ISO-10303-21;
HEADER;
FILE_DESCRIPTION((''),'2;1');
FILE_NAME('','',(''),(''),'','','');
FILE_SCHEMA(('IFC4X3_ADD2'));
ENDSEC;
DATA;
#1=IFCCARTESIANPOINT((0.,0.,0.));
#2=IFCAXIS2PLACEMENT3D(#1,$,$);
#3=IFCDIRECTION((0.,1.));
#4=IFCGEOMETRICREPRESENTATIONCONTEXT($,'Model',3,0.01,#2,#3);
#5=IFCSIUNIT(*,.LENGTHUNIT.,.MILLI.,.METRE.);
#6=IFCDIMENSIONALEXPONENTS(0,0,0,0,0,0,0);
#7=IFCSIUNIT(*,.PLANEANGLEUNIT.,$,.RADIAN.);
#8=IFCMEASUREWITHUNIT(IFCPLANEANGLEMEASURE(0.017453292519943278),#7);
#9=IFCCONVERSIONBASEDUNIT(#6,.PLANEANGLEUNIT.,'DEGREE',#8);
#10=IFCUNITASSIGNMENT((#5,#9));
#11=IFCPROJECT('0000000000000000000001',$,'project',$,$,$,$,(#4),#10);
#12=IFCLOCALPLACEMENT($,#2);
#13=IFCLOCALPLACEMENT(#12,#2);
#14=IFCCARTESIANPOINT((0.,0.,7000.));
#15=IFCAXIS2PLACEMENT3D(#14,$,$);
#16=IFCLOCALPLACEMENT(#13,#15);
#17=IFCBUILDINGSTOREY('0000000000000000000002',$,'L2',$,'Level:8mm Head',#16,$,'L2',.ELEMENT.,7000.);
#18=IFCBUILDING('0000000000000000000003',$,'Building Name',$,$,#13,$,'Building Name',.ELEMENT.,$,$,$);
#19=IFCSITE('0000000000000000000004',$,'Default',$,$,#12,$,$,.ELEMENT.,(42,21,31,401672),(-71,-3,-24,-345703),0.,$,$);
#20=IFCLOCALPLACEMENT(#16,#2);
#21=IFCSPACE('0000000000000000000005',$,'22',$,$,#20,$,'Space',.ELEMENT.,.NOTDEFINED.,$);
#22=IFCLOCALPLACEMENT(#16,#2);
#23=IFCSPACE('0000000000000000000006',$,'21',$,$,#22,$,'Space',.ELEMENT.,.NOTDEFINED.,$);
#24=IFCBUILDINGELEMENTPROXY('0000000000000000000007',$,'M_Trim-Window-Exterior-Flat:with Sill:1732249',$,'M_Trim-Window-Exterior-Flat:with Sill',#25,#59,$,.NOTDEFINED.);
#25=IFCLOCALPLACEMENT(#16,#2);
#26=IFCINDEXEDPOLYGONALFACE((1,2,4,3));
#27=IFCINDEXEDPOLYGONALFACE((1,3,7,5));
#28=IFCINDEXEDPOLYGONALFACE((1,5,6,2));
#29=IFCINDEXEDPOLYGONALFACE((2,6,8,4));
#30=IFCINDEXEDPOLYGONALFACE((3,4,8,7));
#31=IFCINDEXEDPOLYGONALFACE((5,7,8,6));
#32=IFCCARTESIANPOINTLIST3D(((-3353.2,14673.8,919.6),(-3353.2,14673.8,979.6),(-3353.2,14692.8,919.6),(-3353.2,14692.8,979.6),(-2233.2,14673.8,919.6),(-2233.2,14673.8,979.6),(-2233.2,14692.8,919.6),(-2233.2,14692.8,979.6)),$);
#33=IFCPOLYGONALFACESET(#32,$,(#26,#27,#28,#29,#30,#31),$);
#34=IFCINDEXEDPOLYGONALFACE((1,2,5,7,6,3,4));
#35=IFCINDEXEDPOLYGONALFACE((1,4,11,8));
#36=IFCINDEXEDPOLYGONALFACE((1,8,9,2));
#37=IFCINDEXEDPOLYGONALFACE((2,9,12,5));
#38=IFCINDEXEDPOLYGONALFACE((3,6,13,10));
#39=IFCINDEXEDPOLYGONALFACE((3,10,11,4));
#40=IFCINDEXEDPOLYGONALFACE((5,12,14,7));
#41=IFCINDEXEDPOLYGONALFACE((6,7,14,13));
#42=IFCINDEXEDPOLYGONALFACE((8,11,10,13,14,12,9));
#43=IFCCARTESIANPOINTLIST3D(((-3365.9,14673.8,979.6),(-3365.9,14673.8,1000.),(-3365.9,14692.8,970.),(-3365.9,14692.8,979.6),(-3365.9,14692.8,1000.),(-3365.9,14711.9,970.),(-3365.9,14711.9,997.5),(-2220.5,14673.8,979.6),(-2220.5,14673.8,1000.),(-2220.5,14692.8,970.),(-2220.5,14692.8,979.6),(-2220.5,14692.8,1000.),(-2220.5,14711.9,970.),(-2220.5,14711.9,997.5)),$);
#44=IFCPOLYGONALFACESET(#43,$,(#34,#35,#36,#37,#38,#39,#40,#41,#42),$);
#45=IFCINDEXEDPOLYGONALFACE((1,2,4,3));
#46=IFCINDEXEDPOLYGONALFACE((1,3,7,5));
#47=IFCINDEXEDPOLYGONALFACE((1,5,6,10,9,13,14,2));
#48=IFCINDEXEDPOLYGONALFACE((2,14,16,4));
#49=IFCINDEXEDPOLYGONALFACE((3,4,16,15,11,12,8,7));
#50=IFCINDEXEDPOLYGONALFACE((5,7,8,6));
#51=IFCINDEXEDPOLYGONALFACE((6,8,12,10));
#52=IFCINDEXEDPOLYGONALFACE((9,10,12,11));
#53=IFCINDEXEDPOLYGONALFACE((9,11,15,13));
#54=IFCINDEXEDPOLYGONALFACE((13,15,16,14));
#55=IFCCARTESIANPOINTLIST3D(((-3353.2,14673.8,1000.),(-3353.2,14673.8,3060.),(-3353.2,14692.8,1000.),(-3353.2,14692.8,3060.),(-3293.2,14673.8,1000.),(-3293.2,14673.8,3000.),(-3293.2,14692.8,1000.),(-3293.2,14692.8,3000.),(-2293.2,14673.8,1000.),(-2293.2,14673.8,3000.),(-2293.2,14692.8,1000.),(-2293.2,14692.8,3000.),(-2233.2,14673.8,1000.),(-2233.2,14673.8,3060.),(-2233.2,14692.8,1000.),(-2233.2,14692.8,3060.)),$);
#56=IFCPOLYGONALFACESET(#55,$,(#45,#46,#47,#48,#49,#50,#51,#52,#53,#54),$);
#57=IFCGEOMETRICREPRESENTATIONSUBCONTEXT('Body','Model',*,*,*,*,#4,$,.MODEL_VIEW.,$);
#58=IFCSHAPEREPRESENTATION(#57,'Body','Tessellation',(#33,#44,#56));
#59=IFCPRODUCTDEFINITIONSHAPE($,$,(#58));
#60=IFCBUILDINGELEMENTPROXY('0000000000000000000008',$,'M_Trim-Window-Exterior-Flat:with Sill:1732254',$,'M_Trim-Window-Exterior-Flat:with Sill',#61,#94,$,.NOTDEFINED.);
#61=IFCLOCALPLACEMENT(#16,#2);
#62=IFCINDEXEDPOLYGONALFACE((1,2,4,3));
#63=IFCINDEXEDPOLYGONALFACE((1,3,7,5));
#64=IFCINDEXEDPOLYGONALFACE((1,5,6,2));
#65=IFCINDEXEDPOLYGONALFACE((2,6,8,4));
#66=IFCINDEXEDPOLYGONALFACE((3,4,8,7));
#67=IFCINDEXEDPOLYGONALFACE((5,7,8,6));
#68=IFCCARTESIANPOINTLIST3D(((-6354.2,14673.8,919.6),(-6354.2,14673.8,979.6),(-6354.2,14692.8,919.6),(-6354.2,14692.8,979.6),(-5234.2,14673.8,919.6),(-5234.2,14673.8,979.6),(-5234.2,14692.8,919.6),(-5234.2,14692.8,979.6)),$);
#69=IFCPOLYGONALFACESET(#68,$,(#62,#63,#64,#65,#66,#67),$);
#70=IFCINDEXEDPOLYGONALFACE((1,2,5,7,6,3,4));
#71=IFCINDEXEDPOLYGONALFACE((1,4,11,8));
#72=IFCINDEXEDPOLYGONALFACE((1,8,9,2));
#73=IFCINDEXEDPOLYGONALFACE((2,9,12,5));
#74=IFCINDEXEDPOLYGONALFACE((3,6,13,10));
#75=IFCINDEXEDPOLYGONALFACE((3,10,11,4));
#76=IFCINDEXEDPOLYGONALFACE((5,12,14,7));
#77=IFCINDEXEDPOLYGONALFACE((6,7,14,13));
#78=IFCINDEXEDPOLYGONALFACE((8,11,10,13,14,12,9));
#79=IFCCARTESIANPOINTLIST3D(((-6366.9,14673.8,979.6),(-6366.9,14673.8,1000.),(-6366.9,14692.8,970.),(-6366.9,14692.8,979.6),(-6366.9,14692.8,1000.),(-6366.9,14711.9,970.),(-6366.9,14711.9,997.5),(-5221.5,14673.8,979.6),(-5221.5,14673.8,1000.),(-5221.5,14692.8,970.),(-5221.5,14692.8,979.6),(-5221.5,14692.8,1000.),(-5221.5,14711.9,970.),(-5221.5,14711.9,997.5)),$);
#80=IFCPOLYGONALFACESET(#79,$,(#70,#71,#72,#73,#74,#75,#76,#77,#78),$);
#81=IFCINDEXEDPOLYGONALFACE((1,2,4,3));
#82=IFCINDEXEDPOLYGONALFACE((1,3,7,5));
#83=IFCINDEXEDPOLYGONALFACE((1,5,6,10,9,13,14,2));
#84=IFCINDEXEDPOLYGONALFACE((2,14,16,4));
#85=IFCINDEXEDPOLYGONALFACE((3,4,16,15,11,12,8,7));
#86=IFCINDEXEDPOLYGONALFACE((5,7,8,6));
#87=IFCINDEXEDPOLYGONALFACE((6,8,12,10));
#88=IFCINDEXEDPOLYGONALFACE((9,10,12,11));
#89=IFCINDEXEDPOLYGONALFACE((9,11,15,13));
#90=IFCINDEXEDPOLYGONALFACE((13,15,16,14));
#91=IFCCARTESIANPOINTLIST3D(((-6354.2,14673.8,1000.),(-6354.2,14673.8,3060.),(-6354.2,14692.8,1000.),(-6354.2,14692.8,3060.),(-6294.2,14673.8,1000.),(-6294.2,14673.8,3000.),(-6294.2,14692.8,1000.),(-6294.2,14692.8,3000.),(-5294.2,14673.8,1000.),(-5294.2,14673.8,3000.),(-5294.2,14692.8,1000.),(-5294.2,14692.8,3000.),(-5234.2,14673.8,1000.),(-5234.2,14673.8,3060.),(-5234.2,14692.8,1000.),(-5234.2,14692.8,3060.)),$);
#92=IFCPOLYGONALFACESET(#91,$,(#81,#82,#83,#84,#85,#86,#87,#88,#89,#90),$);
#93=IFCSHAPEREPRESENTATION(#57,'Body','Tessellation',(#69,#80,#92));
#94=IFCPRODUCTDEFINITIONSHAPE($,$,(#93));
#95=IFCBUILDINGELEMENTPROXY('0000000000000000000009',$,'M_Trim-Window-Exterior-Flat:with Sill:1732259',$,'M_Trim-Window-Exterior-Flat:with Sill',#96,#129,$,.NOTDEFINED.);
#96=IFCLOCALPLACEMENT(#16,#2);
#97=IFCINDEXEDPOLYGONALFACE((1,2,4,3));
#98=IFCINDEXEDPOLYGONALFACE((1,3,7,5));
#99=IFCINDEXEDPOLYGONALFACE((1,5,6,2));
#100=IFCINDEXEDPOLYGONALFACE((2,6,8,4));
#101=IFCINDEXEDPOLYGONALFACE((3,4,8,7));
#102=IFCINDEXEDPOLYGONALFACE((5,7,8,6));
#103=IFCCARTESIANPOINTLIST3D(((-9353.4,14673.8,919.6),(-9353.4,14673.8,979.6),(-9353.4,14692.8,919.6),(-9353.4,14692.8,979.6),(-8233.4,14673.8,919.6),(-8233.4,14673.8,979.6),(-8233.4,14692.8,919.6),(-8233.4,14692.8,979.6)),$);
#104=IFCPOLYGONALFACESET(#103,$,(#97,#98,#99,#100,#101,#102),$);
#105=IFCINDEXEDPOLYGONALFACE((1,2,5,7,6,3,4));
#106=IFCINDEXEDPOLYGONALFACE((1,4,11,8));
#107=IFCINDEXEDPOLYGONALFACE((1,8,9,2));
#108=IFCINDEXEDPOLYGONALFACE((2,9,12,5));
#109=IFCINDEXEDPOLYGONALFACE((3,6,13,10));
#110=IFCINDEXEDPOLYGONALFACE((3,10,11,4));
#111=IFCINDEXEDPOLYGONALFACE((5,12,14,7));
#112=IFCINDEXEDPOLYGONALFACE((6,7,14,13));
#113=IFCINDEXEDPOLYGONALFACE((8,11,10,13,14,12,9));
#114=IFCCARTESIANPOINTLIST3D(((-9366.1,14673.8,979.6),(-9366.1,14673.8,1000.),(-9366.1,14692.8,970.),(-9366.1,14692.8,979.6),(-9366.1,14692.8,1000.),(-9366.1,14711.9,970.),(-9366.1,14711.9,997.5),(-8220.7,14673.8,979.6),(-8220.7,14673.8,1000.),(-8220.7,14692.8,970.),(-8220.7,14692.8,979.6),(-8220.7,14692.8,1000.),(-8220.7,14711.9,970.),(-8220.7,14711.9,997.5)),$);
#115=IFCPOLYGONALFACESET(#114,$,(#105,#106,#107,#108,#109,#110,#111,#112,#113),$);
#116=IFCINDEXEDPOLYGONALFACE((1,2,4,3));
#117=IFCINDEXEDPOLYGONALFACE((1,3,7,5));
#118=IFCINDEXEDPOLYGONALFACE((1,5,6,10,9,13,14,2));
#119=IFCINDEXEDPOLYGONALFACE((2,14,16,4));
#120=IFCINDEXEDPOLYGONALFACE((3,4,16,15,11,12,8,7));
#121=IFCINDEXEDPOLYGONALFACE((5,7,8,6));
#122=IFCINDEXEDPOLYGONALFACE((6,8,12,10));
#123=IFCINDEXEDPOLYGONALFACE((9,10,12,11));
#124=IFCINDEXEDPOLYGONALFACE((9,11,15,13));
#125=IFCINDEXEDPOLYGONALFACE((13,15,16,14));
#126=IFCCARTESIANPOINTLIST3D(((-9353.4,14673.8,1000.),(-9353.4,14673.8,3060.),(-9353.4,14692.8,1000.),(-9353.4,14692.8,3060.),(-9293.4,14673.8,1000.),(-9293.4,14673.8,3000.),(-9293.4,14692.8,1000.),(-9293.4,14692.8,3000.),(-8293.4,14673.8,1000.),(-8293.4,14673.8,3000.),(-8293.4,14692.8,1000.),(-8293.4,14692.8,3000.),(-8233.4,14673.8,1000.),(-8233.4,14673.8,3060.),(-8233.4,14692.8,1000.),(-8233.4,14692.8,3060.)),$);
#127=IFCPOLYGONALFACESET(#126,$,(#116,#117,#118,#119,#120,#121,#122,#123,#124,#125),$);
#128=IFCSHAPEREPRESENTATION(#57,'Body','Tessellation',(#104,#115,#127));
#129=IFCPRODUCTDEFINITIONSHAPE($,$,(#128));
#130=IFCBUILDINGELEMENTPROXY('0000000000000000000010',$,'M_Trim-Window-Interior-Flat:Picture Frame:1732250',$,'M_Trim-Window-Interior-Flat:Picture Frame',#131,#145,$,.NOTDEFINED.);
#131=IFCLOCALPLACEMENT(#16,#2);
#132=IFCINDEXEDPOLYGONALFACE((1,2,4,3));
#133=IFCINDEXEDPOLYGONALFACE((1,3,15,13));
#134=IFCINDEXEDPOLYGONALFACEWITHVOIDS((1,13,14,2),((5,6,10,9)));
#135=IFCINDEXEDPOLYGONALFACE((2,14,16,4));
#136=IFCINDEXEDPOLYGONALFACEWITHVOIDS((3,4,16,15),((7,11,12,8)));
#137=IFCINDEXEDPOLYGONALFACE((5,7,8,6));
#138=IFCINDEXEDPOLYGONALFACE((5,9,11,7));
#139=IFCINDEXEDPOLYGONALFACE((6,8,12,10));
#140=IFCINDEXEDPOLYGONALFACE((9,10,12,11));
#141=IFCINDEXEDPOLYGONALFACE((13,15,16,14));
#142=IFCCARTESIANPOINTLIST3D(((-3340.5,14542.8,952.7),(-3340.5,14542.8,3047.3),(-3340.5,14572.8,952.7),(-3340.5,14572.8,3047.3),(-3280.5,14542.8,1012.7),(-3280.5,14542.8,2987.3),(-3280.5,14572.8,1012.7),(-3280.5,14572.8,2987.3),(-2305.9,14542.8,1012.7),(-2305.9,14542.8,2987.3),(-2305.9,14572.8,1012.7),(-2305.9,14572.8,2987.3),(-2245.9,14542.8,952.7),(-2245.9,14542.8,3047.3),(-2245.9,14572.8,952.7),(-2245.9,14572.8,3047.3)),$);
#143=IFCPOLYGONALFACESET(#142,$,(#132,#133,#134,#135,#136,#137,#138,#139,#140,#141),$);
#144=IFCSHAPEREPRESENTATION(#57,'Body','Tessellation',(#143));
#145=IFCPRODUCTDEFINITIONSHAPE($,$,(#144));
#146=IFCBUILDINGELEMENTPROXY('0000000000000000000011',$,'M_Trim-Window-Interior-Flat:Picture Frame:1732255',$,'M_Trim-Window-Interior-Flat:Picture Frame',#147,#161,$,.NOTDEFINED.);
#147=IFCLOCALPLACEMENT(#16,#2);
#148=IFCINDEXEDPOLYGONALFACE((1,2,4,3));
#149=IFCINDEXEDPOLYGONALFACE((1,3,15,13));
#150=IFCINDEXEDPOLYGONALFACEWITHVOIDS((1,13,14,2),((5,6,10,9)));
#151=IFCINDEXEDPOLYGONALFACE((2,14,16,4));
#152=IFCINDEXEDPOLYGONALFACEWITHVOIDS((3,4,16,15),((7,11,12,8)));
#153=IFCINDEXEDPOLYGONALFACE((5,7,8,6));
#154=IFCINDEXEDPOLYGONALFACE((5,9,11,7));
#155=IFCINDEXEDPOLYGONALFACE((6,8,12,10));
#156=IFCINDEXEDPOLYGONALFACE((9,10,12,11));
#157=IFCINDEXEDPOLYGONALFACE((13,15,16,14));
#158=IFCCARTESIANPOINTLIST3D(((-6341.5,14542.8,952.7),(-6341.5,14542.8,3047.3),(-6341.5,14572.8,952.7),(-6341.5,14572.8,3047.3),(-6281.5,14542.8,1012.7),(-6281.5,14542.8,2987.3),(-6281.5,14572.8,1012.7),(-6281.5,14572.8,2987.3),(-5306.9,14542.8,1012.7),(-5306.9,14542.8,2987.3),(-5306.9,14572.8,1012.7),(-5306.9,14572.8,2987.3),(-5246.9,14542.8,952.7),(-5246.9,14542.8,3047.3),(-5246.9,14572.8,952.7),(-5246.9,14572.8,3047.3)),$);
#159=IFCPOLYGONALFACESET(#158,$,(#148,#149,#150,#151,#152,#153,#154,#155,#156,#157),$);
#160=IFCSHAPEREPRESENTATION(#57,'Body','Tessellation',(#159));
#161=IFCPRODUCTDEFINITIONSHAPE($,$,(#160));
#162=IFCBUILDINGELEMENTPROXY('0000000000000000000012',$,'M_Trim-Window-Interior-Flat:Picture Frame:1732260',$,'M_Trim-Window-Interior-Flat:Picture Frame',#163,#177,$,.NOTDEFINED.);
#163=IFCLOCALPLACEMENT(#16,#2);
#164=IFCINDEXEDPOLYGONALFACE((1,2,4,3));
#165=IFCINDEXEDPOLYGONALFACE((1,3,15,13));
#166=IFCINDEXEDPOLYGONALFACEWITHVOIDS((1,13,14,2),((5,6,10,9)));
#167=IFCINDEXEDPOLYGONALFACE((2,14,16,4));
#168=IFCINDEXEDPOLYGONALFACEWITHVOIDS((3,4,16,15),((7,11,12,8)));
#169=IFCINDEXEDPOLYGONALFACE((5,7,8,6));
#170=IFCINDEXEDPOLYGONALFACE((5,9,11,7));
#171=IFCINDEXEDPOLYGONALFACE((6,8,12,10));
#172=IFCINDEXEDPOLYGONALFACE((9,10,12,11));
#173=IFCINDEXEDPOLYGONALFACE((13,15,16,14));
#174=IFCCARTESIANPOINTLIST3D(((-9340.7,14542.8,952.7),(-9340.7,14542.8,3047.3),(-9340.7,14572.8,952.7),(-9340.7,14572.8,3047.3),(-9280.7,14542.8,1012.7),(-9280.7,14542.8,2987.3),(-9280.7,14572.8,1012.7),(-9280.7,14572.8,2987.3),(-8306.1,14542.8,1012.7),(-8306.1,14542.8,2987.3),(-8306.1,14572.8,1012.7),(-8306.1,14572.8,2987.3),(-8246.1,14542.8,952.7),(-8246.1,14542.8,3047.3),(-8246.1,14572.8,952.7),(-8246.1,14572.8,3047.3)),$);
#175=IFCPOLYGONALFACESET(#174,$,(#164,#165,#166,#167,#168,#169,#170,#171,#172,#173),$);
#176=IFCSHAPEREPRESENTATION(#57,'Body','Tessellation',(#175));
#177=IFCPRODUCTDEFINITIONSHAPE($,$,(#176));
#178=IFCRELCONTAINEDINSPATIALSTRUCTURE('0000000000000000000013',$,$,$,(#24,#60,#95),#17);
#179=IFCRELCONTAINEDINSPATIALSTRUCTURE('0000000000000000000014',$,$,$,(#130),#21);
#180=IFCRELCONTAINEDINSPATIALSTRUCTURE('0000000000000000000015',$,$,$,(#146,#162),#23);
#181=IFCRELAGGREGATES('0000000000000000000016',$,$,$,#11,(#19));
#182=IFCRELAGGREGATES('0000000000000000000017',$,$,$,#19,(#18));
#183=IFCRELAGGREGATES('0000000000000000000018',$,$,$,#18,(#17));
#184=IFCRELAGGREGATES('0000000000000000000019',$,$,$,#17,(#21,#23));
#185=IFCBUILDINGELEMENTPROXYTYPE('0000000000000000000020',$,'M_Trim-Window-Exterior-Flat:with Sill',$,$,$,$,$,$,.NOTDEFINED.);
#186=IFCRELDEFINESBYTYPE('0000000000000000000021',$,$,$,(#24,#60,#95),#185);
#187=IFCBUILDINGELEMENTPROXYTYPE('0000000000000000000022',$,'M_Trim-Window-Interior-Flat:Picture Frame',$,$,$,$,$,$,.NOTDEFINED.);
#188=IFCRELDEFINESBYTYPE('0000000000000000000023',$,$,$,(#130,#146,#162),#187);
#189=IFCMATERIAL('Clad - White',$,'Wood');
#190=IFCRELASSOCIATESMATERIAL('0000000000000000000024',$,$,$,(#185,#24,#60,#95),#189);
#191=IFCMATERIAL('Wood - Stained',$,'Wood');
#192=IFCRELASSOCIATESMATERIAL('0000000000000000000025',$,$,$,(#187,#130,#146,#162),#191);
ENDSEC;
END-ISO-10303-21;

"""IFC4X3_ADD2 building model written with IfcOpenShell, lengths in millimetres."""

from ifc_helpers import new_model, entity, si_unit, converted_unit, direction, frame, frame_2d, origin, place, context, subcontext, project, spatial, polyline, rectangle, outline, extrude, source, transform, mapped, material, type_object, type_shapes, element, save


model = new_model("IFC4X3_ADD2")

# Units and contexts
model_context = context("Model", 3, precision=0.01, world=origin(), true_north=direction((0.0, 1.0)))
body_context = subcontext(model_context, "Body", "Model", "MODEL_VIEW")
ifc_project = project(units=[si_unit("LENGTHUNIT", "METRE", prefix="MILLI"), converted_unit("PLANEANGLEUNIT", "DEGREE", entity("IfcPlaneAngleMeasure", 0.017453292519943278), si_unit("PLANEANGLEUNIT", "RADIAN"), dimensions=[0, 0, 0, 0, 0, 0, 0])], contexts=[model_context])

# Site, building, storey
site_placement = place(None, origin())
site = spatial("IfcSite", under=ifc_project, at=site_placement, Name="Default", CompositionType="ELEMENT", RefLatitude=(42, 21, 31, 401672), RefLongitude=(-71, -3, -24, -345703), RefElevation=0.0)
building_placement = place(site_placement, origin())
building = spatial("IfcBuilding", under=site, at=building_placement, Name="Building Name", LongName="Building Name", CompositionType="ELEMENT")
storey_placement = place(building_placement, frame((0.0, 0.0, 7000.0)))
storey = spatial("IfcBuildingStorey", under=building, at=storey_placement, Name="L2", ObjectType="Level:8mm Head", LongName="L2", CompositionType="ELEMENT", Elevation=7000.0)

# Building element proxies
ifc_material_1 = material(Name="Clad - White", Category="Wood")
ifc_material_2 = material(Name="Wood - Stained", Category="Wood")
building_element_proxy_type_1 = type_object("IfcBuildingElementProxyType", Name="M_Trim-Window-Exterior-Flat:with Sill", PredefinedType="NOTDEFINED", material=ifc_material_1)
shared_shape_1 = source(origin(), body_context, "Body", "SweptSolid", [
    extrude(rectangle(XDim=1120.0, YDim=60.0, at=frame_2d((0.0, 0.0), x_axis=(1.0, 0.0))), frame((0.0, -2050.4, 0.0), z_axis=(0.0, 0.0, 1.0), x_axis=(-1.0, 0.0, 0.0)), (0.0, 0.0, 1.0), 19.0),
    extrude(outline(polyline([(-19.0, -15.2), (0.0, -15.2), (0.0, -5.7), (19.0, -5.7), (19.0, 14.8), (0.0, 14.8), (-19.0, 12.3), (-19.0, -15.2)])), frame((-572.7, -2014.8, 19.0), z_axis=(1.0, 0.0, 0.0), x_axis=(0.0, 0.0, -1.0)), (0.0, 0.0, 1.0), 1145.4),
    extrude(outline(polyline([(-1045.0, -560.0), (1015.0, -560.0), (1015.0, -500.0), (-985.0, -500.0), (-985.0, 500.0), (1015.0, 500.0), (1015.0, 560.0), (-1045.0, 560.0), (-1045.0, -560.0)])), frame((0.0, -985.0, 0.0), z_axis=(0.0, 0.0, 1.0), x_axis=(0.0, -1.0, 0.0)), (0.0, 0.0, 1.0), 19.0),
])
type_shapes(building_element_proxy_type_1, [shared_shape_1])
for number, where, z_axis, x_axis, name in (
    (1, (-2793.2, 14673.8, 3000.0), (0.0, 1.0, 0.0), (-1.0, 0.0, 0.0), "M_Trim-Window-Exterior-Flat:with Sill:1732249"),
    (2, (-5794.2, 14673.8, 3000.0), (0.0, 1.0, 0.0), (-1.0, 0.0, 0.0), "M_Trim-Window-Exterior-Flat:with Sill:1732254"),
    (3, (-8793.4, 14673.8, 3000.0), (0.0, 1.0, 0.0), (-1.0, 0.0, 0.0), "M_Trim-Window-Exterior-Flat:with Sill:1732259"),
):
    element("IfcBuildingElementProxy", number, at=place(storey_placement, frame(where, z_axis=z_axis, x_axis=x_axis)), inside=storey, type_object=building_element_proxy_type_1, material=ifc_material_1, Name=name, ObjectType="M_Trim-Window-Exterior-Flat:with Sill", PredefinedType="NOTDEFINED", context=body_context, shape_type="MappedRepresentation", body=[
        mapped(shared_shape_1, transform((0.0, 0.0, 0.0), scale=1.0)),
    ])

# Shared definitions
space_1_placement = place(storey_placement, origin())
space_1 = spatial("IfcSpace", under=storey, at=space_1_placement, Name="22", LongName="Space", CompositionType="ELEMENT", PredefinedType="NOTDEFINED")

# Building element proxy
building_element_proxy_type_2 = type_object("IfcBuildingElementProxyType", Name="M_Trim-Window-Interior-Flat:Picture Frame", PredefinedType="NOTDEFINED", material=ifc_material_2)
shared_shape_2 = source(origin(), body_context, "Body", "SweptSolid", [
    extrude(outline(polyline([(-547.3, -1047.3), (547.3, -1047.3), (547.3, 1047.3), (-547.3, 1047.3), (-547.3, -1047.3)]), holes=[polyline([(-487.3, -987.3), (-487.3, 987.3), (487.3, 987.3), (487.3, -987.3), (-487.3, -987.3)])]), frame((0.0, -1000.0, 0.0), z_axis=(0.0, 0.0, 1.0), x_axis=(-1.0, 0.0, 0.0)), (0.0, 0.0, 1.0), 30.0),
])
type_shapes(building_element_proxy_type_2, [shared_shape_2])
proxy_1_placement = place(space_1_placement, frame((-2793.2, 14572.8, 3000.0), z_axis=(0.0, -1.0, 0.0), x_axis=(1.0, 0.0, 0.0)))
element("IfcBuildingElementProxy", 4, at=proxy_1_placement, inside=space_1, type_object=building_element_proxy_type_2, material=ifc_material_2, Name="M_Trim-Window-Interior-Flat:Picture Frame:1732250", ObjectType="M_Trim-Window-Interior-Flat:Picture Frame", PredefinedType="NOTDEFINED", context=body_context, shape_type="MappedRepresentation", body=[
    mapped(shared_shape_2, transform((0.0, 0.0, 0.0), scale=1.0)),
])

# Shared definitions
space_2_placement = place(storey_placement, origin())
space_2 = spatial("IfcSpace", under=storey, at=space_2_placement, Name="21", LongName="Space", CompositionType="ELEMENT", PredefinedType="NOTDEFINED")

# Building element proxies
for number, where, z_axis, x_axis, name in (
    (5, (-5794.2, 14572.8, 3000.0), (0.0, -1.0, 0.0), (1.0, 0.0, 0.0), "M_Trim-Window-Interior-Flat:Picture Frame:1732255"),
    (6, (-8793.4, 14572.8, 3000.0), (0.0, -1.0, 0.0), (1.0, 0.0, 0.0), "M_Trim-Window-Interior-Flat:Picture Frame:1732260"),
):
    element("IfcBuildingElementProxy", number, at=place(space_2_placement, frame(where, z_axis=z_axis, x_axis=x_axis)), inside=space_2, type_object=building_element_proxy_type_2, material=ifc_material_2, Name=name, ObjectType="M_Trim-Window-Interior-Flat:Picture Frame", PredefinedType="NOTDEFINED", context=body_context, shape_type="MappedRepresentation", body=[
        mapped(shared_shape_2, transform((0.0, 0.0, 0.0), scale=1.0)),
    ])

save(model, "model.ifc")
